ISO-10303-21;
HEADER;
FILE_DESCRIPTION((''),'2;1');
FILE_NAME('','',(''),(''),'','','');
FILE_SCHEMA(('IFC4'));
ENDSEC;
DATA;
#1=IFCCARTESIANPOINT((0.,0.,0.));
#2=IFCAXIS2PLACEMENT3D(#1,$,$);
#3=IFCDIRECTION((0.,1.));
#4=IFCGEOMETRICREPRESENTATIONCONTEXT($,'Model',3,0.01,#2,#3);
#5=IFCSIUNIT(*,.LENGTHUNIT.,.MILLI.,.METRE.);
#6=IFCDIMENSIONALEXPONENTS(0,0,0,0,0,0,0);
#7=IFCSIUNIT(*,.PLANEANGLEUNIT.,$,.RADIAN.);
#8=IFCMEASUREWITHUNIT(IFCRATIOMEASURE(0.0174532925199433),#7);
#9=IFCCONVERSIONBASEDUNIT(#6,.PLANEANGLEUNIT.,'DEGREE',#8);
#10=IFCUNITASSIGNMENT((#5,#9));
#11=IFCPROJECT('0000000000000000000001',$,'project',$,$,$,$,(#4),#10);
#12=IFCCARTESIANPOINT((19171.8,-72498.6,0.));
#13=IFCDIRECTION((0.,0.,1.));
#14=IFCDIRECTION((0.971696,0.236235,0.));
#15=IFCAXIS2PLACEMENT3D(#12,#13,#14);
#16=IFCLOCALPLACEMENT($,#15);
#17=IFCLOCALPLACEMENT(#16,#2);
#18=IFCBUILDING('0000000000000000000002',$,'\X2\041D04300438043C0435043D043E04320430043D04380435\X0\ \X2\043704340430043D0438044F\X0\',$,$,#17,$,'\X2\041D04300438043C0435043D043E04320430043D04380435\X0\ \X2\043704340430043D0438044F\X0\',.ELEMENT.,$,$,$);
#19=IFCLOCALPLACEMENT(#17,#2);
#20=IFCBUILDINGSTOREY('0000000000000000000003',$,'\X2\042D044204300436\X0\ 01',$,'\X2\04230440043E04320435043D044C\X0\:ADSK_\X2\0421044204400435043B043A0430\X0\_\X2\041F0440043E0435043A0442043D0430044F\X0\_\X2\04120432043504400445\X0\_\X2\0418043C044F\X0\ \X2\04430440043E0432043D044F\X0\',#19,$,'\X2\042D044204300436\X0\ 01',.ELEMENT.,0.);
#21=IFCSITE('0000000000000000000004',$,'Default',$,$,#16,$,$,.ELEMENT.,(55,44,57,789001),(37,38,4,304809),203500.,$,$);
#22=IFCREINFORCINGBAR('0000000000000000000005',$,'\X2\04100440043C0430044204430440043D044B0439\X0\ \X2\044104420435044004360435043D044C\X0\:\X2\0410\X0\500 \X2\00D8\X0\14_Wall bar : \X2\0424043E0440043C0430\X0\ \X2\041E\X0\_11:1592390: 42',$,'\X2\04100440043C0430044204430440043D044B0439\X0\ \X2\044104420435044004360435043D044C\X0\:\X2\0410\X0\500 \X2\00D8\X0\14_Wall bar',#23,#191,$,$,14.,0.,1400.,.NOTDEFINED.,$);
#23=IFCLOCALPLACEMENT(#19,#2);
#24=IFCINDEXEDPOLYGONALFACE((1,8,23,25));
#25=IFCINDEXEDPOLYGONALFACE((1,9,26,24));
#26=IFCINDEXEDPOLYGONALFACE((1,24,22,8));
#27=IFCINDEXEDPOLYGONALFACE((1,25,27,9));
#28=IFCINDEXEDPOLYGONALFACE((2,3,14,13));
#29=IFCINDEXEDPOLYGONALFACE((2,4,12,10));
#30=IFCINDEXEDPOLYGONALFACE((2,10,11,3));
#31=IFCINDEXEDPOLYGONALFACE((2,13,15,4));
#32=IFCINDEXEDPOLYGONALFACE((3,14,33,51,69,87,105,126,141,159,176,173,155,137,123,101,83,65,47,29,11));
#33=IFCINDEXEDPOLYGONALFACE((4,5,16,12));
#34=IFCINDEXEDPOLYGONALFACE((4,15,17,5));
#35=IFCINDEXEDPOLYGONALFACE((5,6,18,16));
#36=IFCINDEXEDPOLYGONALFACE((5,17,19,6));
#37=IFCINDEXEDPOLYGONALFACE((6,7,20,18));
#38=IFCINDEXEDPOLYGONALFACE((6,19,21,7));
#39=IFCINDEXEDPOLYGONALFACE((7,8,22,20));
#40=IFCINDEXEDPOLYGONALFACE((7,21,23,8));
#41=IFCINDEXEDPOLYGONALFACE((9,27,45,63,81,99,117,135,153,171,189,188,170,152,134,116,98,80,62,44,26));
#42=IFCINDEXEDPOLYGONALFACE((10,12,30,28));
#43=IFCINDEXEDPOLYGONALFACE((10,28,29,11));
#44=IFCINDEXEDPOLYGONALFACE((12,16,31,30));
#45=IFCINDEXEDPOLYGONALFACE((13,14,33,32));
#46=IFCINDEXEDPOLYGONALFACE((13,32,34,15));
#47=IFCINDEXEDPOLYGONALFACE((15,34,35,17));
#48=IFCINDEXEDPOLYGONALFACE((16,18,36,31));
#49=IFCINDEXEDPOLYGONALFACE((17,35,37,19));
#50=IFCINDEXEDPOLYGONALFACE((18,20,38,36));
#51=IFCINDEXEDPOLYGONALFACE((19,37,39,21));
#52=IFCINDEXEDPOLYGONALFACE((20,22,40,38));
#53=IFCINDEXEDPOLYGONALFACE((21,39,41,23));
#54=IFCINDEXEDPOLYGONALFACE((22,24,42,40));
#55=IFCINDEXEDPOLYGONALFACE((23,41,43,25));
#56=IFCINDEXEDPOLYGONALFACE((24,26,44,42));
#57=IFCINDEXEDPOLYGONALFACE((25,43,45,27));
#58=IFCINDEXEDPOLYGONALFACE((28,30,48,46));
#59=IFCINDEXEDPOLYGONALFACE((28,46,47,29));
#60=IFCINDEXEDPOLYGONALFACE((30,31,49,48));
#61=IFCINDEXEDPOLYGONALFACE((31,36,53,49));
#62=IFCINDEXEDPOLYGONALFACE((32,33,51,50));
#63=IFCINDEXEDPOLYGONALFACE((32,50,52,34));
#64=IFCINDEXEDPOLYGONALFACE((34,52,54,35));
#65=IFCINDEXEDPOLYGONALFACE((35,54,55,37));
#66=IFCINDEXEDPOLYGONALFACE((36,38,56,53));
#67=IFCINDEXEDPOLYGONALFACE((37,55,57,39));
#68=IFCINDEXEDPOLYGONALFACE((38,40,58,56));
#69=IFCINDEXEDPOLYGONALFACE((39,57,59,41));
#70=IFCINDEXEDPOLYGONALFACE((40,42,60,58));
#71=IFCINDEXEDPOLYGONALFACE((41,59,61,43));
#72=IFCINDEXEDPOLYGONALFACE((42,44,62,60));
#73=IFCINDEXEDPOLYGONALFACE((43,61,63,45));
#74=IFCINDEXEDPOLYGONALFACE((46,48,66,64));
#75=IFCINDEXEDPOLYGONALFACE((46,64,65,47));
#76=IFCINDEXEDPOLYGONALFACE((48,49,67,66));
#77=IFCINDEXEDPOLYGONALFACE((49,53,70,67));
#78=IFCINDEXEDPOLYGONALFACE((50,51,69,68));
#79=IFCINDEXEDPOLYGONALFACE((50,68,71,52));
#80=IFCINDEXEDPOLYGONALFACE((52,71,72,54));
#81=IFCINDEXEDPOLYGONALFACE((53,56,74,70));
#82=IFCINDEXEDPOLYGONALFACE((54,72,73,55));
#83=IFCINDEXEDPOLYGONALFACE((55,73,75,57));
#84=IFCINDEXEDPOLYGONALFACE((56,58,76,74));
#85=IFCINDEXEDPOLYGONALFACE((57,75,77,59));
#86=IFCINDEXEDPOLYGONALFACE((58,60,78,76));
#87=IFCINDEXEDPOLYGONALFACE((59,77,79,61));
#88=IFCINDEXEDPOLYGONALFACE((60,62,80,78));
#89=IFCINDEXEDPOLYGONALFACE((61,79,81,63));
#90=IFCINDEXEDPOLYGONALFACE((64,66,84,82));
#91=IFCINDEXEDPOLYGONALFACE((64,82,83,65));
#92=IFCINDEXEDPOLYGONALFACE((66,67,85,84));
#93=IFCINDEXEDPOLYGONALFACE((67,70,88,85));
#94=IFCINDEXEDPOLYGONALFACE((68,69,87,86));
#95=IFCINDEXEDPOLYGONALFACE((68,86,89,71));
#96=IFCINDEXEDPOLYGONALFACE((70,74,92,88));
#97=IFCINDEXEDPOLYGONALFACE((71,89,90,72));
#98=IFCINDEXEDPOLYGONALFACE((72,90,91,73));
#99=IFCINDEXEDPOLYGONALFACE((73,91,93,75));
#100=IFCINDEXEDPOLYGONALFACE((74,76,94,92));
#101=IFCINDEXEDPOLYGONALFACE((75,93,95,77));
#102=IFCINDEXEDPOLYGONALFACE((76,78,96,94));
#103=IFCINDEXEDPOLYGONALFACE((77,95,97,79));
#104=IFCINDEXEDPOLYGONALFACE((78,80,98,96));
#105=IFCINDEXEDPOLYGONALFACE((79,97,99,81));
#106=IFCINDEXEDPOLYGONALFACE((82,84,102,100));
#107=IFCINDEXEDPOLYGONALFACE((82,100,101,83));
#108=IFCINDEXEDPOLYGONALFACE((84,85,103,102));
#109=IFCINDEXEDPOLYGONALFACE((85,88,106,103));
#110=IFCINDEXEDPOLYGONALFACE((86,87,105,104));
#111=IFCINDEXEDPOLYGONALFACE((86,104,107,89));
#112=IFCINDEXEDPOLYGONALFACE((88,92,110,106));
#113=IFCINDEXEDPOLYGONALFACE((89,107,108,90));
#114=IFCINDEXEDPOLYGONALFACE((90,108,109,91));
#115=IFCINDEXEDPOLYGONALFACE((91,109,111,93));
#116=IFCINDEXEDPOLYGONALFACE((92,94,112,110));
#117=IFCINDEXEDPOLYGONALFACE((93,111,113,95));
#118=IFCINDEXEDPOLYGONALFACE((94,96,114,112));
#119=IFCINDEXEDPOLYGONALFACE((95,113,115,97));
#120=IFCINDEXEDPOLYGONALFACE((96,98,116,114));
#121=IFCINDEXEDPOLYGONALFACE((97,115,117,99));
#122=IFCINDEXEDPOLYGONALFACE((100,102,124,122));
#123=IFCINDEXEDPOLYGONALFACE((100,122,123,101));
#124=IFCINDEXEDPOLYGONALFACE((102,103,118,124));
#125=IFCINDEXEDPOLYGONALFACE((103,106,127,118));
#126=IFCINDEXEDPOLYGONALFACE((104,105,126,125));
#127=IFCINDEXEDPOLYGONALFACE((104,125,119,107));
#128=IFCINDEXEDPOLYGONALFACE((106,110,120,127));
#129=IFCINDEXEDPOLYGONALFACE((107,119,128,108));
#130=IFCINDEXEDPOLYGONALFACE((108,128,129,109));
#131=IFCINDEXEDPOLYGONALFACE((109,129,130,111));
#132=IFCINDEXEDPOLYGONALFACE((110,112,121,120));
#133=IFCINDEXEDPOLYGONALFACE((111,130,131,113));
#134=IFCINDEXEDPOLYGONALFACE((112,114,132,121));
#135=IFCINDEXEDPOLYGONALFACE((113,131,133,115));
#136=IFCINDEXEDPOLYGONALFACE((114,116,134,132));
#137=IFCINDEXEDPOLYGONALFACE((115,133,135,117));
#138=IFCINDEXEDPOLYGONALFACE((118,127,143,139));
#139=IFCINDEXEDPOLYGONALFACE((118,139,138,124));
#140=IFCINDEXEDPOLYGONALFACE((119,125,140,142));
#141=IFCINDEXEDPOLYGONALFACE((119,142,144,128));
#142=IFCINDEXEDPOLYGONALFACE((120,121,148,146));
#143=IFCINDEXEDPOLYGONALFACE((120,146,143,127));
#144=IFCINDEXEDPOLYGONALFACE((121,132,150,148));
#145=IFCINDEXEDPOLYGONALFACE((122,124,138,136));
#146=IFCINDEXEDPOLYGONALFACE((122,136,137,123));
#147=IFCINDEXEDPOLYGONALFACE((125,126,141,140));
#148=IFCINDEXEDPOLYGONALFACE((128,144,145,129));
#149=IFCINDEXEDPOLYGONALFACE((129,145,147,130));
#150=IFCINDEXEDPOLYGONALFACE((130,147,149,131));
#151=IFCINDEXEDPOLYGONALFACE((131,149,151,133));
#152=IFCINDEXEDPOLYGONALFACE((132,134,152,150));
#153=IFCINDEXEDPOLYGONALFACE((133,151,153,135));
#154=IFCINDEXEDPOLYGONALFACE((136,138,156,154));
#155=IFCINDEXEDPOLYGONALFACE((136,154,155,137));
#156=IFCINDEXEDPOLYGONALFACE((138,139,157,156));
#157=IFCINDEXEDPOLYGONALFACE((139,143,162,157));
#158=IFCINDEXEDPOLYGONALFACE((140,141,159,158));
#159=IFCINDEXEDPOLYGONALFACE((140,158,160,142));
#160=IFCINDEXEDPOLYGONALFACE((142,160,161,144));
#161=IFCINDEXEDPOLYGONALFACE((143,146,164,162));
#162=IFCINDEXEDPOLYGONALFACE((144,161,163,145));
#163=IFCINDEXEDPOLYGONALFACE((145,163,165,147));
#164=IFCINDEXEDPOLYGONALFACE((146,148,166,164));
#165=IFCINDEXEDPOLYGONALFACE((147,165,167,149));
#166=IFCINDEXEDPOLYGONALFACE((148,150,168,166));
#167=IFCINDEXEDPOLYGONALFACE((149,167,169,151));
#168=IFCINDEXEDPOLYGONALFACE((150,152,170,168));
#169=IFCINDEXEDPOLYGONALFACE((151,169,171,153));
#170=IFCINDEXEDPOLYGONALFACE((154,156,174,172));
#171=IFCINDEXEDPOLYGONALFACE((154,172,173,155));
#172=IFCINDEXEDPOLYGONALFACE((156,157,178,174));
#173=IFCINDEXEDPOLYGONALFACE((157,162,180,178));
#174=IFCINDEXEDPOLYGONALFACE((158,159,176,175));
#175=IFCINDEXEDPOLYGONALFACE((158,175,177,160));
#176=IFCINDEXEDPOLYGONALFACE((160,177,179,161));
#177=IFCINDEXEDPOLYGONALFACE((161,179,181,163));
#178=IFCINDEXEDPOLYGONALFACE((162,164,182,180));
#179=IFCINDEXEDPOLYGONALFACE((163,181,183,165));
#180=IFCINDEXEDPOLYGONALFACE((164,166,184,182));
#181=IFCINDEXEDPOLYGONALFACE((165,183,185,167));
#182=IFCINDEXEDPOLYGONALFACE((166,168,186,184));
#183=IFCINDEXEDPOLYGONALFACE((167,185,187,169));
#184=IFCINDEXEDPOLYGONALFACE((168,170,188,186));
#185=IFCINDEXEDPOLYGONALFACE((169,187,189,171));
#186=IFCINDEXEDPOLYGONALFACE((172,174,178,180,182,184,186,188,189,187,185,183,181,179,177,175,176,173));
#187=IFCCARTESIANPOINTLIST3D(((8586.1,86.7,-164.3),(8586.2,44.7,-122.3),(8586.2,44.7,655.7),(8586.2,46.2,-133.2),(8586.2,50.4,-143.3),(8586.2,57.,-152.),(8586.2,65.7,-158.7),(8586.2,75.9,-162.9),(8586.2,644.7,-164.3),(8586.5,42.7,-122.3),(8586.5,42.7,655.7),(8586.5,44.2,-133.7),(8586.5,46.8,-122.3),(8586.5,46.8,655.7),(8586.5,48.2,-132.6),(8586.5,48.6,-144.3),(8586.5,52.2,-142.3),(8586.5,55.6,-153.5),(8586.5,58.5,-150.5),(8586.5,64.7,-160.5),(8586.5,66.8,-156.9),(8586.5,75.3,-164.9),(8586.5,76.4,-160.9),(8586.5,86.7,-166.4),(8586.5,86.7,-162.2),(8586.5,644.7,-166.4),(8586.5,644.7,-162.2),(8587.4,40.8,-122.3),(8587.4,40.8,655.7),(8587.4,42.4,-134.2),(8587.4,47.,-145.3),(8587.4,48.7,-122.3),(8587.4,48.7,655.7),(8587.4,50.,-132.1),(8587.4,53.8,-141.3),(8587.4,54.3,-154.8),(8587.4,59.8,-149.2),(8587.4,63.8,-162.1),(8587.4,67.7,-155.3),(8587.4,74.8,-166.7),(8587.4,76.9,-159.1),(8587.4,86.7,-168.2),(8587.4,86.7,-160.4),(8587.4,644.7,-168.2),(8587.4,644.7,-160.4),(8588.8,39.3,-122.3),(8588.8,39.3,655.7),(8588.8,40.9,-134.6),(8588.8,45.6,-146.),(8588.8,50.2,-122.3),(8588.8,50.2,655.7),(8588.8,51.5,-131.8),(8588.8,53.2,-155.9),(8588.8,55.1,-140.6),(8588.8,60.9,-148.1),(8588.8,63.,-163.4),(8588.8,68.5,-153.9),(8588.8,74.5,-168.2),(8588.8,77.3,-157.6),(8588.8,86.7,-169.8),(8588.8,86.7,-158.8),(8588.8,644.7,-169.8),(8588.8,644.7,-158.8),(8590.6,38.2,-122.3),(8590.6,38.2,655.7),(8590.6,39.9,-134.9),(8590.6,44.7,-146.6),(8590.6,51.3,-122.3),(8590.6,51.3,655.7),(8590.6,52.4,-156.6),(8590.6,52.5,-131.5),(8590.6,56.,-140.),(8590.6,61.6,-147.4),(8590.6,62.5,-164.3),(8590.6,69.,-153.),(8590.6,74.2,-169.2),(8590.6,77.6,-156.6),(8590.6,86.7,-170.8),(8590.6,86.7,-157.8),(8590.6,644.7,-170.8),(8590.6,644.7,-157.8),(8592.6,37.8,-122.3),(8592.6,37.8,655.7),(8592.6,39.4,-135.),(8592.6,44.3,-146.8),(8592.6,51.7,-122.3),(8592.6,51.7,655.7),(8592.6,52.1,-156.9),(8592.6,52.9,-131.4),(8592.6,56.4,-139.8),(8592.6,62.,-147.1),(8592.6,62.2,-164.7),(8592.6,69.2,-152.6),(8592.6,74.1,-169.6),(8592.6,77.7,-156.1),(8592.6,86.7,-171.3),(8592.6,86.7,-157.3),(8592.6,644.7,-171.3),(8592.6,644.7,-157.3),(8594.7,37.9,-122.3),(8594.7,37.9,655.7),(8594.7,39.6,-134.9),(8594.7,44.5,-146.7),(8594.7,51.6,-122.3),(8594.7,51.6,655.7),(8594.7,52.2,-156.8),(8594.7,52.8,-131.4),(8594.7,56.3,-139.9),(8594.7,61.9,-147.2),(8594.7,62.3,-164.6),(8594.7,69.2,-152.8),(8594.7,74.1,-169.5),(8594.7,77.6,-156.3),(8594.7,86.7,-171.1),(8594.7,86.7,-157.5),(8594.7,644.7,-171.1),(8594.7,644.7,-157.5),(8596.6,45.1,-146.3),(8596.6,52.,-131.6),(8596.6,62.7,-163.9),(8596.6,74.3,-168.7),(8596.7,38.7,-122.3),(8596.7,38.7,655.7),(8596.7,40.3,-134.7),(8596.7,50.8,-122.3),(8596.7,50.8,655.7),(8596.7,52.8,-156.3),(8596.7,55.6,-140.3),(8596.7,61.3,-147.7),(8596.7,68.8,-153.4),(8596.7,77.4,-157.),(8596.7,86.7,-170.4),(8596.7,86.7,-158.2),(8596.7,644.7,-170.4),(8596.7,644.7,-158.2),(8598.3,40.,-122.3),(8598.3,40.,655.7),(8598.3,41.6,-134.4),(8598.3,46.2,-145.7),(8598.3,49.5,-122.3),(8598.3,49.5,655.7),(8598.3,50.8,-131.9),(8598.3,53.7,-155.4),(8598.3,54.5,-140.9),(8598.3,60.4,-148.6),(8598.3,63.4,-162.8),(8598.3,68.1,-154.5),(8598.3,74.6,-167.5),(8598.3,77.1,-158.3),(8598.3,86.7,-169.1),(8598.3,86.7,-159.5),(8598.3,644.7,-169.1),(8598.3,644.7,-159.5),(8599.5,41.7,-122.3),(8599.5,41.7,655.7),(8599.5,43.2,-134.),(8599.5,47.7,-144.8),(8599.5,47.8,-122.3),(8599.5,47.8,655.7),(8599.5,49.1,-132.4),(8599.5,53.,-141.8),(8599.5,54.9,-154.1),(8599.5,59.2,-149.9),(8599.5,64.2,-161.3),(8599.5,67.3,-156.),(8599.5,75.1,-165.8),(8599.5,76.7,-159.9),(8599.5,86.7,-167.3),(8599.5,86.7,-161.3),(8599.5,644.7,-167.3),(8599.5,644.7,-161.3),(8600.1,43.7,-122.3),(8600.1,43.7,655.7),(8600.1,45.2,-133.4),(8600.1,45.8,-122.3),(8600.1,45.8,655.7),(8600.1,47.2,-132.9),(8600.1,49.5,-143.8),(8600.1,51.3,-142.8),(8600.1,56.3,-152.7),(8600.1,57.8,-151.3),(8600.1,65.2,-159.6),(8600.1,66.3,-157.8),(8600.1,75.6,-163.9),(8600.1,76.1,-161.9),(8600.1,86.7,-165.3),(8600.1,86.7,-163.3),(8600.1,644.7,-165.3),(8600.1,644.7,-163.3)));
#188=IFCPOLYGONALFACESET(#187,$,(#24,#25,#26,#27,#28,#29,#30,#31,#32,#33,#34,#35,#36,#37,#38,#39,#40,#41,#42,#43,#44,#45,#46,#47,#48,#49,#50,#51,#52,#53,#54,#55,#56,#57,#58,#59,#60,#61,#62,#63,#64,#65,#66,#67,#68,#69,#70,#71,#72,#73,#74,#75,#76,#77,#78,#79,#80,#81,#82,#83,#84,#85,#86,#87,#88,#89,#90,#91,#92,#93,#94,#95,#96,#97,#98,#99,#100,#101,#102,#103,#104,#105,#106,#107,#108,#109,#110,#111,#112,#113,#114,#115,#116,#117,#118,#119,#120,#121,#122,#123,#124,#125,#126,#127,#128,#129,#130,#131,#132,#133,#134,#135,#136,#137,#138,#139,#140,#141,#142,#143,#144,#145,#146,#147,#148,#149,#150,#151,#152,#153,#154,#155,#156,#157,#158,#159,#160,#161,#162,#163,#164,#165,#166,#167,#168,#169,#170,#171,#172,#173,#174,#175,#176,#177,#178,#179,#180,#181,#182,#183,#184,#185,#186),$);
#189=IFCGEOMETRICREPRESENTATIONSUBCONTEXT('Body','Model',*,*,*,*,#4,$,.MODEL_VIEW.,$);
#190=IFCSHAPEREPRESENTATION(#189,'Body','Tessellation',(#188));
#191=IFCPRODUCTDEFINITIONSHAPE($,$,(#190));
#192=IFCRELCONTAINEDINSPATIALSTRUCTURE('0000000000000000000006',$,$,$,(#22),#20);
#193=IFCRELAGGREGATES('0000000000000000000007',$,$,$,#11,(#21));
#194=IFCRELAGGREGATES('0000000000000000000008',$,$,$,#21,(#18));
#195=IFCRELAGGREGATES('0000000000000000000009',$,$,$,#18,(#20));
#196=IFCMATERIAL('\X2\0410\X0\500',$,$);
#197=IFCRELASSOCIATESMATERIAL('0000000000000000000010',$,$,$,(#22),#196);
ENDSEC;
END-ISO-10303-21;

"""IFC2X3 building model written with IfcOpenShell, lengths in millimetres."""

from ifc_helpers import new_model, entity, si_unit, converted_unit, direction, frame, origin, place, context, subcontext, project, spatial, material, element, save


model = new_model("IFC2X3")

# Units and contexts
model_context = context("Model", 3, precision=0.01, world=origin(), true_north=direction((0.0, 1.0)))
body_context = subcontext(model_context, "Body", "Model", "MODEL_VIEW")
ifc_project = project(units=[si_unit("LENGTHUNIT", "METRE", prefix="MILLI"), converted_unit("PLANEANGLEUNIT", "DEGREE", entity("IfcRatioMeasure", 0.0174532925199433), si_unit("PLANEANGLEUNIT", "RADIAN"), dimensions=[0, 0, 0, 0, 0, 0, 0])], contexts=[model_context])

# Site, building, storey
site_placement = place(None, frame((19171.8, -72498.6, 0.0), z_axis=(0.0, 0.0, 1.0), x_axis=(0.971696, 0.236235, 0.0)))
site = spatial("IfcSite", under=ifc_project, at=site_placement, Name="Default", CompositionType="ELEMENT", RefLatitude=(55, 44, 57, 789001), RefLongitude=(37, 38, 4, 304809), RefElevation=203500.0)
building_placement = place(site_placement, origin())
building = spatial("IfcBuilding", under=site, at=building_placement, Name="Наименование здания", LongName="Наименование здания", CompositionType="ELEMENT")
storey_placement = place(building_placement, origin())
storey = spatial("IfcBuildingStorey", under=building, at=storey_placement, Name="Этаж 01", ObjectType="Уровень:ADSK_Стрелка_Проектная_Вверх_Имя уровня", LongName="Этаж 01", CompositionType="ELEMENT", Elevation=0.0)

# Reinforcing bar
ifc_material = material(Name="А500")
placement = place(storey_placement, origin())
element("IfcReinforcingBar", 1, at=placement, inside=storey, material=ifc_material, Name="Арматурный стержень:А500 Ø14_Wall bar : Форма О_11:1592390: 42", ObjectType="Арматурный стержень:А500 Ø14_Wall bar", BarLength=1400.0, BarRole="NOTDEFINED", CrossSectionArea=0.0, NominalDiameter=14.0, context=body_context, shape_type="AdvancedSweptSolid", body=[
    entity("IfcSweptDiskSolid", entity("IfcCompositeCurve", [entity("IfcCompositeCurveSegment", "CONTINUOUS", True, entity("IfcPolyline", [entity("IfcCartesianPoint", [8593.1, 44.7, 655.7]), entity("IfcCartesianPoint", [8593.1, 44.7, -122.3])])), entity("IfcCompositeCurveSegment", "CONTINUOUS", True, entity("IfcTrimmedCurve", entity("IfcCircle", entity("IfcAxis2Placement3D", entity("IfcCartesianPoint", [8593.1, 86.7, -122.3]), entity("IfcDirection", [1.0, 0.0, 0.0]), entity("IfcDirection", [0.0, 0.0, -1.0])), 42.0), [entity("IfcParameterValue", 270.0)], [entity("IfcParameterValue", 360.0)], True, "PARAMETER")), entity("IfcCompositeCurveSegment", "CONTINUOUS", True, entity("IfcPolyline", [entity("IfcCartesianPoint", [8593.1, 86.7, -164.3]), entity("IfcCartesianPoint", [8593.1, 644.7, -164.3])]))], False), 7.0, None, 0.0, 92.0),
])

save(model, "model.ifc")
